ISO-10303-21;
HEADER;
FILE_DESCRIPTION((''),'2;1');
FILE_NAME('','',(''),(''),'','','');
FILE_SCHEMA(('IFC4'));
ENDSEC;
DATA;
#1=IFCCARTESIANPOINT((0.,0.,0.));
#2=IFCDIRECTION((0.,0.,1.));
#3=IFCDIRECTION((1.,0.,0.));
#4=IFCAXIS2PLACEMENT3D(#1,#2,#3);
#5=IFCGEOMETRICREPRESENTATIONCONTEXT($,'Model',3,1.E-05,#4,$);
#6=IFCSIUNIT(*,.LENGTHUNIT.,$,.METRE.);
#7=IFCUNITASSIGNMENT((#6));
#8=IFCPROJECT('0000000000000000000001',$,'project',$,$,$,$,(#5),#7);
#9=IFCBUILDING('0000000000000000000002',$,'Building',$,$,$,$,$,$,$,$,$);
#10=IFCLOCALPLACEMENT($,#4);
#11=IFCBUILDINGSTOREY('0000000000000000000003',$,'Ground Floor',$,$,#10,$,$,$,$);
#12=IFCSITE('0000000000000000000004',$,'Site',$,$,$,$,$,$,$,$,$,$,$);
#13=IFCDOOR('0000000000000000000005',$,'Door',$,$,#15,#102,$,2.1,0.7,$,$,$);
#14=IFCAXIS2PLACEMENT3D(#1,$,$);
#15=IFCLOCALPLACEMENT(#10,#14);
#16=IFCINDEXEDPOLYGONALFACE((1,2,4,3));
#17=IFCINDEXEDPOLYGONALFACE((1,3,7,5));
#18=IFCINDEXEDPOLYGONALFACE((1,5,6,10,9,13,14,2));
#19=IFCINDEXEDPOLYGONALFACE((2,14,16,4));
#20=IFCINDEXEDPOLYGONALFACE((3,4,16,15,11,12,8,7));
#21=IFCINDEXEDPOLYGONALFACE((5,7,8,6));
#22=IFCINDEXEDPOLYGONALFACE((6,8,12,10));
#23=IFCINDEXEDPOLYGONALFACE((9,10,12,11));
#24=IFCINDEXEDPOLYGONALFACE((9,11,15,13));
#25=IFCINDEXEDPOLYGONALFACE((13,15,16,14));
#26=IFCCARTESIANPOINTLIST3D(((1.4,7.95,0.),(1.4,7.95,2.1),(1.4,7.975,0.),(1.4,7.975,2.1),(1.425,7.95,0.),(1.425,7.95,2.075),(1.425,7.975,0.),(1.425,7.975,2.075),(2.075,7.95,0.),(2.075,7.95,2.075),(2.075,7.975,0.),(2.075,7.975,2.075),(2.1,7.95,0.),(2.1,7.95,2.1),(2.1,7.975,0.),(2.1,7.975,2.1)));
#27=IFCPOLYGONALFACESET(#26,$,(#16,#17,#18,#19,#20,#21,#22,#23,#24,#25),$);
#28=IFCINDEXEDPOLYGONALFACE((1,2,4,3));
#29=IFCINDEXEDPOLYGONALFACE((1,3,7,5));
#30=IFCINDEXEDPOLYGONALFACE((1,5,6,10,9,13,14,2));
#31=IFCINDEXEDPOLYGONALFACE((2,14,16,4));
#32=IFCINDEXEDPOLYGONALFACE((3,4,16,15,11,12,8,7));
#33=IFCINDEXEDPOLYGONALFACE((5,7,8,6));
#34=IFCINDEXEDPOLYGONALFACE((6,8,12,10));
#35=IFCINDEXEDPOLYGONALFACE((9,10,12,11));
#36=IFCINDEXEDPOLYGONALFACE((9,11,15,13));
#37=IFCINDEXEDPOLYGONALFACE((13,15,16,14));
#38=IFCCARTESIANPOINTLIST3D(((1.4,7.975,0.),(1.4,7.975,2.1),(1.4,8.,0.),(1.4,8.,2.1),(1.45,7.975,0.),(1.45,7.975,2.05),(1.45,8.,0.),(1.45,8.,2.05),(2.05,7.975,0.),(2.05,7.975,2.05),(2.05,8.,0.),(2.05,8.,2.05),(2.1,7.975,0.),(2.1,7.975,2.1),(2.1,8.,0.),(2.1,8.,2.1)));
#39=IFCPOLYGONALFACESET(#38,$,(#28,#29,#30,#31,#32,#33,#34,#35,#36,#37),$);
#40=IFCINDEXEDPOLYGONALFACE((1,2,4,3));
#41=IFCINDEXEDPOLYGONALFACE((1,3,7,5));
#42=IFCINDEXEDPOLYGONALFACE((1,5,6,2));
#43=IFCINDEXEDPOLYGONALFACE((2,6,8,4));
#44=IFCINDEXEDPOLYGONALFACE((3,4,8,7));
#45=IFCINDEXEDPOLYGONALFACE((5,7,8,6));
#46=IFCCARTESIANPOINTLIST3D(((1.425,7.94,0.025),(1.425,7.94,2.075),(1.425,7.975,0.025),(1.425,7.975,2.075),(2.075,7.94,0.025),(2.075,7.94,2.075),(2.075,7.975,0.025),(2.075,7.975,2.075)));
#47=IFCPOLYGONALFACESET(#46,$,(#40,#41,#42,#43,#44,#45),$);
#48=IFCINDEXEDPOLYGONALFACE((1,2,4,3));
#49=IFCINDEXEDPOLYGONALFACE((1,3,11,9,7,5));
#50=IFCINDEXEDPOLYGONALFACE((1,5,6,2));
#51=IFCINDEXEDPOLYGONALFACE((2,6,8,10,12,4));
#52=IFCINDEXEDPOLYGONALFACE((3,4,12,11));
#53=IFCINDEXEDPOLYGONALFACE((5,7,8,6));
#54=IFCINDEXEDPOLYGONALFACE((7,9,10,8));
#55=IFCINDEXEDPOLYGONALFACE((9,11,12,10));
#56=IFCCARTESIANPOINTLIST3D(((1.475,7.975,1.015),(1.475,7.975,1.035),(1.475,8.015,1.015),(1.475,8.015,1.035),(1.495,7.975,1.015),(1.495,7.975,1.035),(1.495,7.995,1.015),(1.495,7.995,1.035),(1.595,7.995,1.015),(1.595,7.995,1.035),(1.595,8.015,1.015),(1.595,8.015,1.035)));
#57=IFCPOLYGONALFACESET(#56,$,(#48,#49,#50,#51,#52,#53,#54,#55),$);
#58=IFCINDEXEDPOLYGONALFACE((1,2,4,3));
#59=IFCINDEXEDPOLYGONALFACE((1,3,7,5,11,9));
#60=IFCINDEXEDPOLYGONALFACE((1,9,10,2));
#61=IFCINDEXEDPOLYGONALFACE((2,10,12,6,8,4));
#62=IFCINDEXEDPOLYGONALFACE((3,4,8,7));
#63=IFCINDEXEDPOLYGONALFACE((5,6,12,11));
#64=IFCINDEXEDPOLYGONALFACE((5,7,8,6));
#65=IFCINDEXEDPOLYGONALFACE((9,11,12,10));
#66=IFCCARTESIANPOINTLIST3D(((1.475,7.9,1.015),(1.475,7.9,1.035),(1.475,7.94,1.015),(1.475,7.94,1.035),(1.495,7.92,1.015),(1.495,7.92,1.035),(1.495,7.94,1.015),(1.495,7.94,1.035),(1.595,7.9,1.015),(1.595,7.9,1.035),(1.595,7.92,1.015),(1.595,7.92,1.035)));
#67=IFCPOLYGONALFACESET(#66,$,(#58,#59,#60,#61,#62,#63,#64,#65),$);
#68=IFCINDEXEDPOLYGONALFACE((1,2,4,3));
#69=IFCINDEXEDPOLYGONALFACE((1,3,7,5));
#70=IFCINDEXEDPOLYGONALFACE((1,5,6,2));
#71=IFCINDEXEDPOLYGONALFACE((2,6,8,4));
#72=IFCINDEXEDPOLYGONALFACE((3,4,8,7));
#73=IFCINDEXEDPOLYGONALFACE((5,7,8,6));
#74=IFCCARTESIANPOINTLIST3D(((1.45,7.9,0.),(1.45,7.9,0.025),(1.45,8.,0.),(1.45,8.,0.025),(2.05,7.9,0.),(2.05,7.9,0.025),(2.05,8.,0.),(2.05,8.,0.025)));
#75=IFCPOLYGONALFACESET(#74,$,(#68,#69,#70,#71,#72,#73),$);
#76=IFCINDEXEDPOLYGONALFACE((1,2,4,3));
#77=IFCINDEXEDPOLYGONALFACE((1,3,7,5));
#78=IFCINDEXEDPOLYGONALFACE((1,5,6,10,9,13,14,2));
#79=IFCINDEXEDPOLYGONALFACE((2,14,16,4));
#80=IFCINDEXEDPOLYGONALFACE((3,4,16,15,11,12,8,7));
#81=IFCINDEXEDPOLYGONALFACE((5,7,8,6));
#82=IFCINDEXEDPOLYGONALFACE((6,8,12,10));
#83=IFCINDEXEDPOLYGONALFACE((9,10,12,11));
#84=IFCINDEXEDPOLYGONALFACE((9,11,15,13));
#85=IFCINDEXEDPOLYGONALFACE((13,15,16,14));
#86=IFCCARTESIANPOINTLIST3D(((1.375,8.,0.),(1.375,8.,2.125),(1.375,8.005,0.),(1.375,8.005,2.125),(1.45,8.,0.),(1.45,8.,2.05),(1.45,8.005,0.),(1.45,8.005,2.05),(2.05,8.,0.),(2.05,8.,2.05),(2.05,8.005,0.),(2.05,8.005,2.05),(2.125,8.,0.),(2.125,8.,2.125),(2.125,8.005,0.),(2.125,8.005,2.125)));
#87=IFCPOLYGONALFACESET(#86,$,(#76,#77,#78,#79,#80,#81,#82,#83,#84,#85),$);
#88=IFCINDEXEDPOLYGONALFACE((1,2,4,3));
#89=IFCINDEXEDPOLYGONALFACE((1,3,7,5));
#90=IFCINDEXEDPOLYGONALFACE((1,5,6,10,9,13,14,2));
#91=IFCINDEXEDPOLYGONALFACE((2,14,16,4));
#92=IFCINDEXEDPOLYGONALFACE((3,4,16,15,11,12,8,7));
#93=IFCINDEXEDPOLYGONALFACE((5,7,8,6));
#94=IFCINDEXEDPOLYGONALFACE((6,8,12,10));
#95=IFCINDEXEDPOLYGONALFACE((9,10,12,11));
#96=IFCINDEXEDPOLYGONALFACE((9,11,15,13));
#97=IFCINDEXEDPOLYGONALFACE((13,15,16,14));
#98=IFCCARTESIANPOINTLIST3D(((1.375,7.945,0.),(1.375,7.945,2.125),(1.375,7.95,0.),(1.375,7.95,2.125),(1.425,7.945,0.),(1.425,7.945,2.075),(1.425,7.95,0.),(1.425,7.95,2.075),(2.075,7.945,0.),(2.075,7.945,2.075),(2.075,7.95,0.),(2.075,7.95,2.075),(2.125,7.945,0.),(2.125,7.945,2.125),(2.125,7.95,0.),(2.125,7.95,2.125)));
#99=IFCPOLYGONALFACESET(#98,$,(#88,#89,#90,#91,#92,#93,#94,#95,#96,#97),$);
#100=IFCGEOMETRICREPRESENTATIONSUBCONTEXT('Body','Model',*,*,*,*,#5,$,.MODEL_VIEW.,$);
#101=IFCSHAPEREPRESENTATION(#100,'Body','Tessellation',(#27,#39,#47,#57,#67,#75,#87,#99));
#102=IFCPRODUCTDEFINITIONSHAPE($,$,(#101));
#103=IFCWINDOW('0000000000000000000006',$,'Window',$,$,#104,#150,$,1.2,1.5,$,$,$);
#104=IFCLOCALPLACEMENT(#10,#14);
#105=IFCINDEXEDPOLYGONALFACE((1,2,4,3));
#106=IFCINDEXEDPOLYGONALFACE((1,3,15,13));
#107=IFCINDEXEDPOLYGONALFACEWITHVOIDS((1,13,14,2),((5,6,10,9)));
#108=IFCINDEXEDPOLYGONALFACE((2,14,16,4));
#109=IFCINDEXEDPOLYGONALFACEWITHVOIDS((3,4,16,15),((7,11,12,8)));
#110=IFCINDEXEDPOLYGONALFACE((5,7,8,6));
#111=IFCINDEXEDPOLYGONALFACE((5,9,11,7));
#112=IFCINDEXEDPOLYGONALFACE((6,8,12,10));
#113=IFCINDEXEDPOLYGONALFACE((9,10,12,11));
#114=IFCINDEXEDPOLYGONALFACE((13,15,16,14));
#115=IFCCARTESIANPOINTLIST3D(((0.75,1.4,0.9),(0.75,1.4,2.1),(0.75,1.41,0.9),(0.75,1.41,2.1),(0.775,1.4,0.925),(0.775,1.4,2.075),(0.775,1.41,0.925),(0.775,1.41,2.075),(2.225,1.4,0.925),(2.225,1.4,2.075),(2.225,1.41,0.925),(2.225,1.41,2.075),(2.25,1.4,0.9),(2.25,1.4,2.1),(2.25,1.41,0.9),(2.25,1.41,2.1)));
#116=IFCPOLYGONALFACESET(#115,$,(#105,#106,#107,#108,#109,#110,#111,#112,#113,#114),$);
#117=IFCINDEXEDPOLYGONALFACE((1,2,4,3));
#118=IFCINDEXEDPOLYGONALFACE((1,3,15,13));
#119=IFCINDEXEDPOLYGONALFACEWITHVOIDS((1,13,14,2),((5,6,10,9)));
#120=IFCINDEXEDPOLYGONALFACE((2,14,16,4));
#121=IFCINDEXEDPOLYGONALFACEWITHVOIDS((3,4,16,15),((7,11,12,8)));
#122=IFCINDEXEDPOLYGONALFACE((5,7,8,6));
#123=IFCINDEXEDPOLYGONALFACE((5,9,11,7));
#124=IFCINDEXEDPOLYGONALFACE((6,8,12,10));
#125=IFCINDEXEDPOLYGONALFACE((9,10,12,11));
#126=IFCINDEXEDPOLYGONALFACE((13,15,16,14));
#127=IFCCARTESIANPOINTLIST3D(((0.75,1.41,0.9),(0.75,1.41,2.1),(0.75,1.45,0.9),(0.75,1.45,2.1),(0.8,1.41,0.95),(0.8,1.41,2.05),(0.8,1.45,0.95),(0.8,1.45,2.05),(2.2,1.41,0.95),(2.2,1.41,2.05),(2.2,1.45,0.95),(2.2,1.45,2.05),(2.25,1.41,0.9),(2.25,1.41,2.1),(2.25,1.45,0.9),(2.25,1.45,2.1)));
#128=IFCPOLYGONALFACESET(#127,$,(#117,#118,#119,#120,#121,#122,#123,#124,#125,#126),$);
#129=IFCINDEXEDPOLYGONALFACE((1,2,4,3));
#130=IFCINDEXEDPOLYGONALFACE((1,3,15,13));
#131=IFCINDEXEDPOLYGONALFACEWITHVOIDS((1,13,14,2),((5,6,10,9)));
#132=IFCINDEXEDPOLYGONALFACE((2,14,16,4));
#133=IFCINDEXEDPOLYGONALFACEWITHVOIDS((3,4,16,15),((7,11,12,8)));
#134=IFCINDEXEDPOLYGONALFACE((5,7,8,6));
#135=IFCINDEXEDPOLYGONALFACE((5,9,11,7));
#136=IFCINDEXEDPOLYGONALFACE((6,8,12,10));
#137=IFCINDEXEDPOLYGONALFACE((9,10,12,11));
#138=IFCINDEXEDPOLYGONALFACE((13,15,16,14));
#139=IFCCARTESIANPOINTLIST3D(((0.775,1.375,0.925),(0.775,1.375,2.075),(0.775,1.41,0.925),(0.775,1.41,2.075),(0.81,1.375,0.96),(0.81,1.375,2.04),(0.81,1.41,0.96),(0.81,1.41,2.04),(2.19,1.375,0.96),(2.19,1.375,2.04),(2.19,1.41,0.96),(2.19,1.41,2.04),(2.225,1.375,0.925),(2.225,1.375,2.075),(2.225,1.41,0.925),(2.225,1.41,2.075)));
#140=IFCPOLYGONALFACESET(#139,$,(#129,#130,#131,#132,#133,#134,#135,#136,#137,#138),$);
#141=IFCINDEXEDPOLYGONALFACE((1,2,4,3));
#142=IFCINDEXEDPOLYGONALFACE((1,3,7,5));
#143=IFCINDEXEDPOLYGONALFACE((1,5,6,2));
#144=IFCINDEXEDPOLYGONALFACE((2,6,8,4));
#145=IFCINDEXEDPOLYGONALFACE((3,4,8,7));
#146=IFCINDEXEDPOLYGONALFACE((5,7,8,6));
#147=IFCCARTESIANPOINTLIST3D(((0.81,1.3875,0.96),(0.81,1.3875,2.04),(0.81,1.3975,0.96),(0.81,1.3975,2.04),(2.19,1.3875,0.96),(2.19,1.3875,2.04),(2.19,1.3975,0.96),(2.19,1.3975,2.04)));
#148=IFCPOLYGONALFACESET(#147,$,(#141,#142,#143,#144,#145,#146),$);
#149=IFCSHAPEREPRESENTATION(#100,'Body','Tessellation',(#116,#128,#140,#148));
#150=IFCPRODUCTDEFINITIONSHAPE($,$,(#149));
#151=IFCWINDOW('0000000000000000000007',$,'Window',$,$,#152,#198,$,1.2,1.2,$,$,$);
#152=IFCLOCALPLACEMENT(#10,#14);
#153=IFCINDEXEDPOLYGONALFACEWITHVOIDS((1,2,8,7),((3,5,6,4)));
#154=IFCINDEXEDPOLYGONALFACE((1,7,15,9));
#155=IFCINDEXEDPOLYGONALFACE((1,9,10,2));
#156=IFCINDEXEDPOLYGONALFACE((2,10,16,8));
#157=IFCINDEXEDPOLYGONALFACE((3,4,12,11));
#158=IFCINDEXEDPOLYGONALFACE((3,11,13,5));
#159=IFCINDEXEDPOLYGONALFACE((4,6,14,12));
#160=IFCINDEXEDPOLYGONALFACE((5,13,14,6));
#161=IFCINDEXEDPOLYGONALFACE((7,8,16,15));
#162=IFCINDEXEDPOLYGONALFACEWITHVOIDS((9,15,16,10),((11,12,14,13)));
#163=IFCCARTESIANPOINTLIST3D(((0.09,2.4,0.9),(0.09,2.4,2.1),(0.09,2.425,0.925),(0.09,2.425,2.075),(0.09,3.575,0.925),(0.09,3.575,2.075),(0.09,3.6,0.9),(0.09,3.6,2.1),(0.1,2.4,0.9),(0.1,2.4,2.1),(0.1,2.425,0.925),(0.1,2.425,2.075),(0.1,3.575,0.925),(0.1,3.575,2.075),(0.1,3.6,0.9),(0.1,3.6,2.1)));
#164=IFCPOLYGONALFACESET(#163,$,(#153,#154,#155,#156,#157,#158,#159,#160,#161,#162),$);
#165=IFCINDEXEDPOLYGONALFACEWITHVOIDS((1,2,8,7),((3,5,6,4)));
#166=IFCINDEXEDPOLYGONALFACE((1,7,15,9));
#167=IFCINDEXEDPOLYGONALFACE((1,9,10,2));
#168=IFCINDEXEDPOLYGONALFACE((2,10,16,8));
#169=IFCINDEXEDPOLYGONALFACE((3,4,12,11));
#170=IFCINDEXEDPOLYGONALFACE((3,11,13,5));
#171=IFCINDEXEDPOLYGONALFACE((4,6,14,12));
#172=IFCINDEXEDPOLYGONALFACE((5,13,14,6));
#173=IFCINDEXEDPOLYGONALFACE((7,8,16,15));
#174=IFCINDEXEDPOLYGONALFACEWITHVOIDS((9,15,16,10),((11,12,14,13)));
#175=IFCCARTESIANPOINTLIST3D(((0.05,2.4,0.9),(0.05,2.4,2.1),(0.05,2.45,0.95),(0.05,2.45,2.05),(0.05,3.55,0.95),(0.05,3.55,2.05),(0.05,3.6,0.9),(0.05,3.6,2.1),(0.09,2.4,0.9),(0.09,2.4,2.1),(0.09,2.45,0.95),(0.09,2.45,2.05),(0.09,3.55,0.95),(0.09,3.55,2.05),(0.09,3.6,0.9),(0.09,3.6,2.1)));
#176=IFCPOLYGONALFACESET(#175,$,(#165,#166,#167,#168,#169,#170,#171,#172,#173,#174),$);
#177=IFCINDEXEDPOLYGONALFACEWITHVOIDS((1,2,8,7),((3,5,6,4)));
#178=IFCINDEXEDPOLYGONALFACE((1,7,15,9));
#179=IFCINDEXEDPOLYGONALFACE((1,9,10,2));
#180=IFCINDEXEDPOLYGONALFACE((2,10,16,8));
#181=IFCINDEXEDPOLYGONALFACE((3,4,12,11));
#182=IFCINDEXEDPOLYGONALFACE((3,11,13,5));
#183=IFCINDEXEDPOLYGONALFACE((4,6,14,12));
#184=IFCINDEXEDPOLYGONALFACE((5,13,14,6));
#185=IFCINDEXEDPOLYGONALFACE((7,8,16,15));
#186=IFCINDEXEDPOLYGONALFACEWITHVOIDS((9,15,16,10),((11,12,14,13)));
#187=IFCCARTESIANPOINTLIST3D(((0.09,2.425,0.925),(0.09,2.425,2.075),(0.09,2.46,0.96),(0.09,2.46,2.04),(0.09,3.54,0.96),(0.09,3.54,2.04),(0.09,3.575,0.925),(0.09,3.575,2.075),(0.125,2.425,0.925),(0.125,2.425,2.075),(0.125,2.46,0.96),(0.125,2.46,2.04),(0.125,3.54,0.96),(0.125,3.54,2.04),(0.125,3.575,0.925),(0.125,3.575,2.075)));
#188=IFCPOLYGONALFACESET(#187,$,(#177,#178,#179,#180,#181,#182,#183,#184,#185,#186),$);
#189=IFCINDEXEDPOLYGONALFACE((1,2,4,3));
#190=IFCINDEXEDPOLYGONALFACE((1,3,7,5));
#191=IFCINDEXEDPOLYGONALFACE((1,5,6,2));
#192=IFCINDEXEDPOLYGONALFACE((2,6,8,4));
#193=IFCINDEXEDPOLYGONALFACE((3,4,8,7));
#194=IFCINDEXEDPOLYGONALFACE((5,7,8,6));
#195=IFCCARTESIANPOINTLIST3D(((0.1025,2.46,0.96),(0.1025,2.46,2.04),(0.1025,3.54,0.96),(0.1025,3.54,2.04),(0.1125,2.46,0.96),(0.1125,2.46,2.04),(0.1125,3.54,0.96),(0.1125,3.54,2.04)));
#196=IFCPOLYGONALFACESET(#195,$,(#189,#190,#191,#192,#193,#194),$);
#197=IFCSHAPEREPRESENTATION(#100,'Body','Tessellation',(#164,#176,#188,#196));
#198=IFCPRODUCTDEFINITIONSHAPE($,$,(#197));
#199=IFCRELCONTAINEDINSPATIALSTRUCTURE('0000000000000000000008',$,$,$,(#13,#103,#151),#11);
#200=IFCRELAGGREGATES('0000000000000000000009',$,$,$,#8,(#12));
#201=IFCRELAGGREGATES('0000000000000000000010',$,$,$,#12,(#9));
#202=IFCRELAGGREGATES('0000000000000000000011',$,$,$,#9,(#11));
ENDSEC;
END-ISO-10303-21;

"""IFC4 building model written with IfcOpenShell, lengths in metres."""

from ifc_helpers import new_model, si_unit, frame, origin_with_axes, place, context, subcontext, project, spatial, line, indexed_curve, outline, extrude, element, save


model = new_model("IFC4")

# Units and contexts
model_context = context("Model", 3, precision=1e-05, world=origin_with_axes())
body_context = subcontext(model_context, "Body", "Model", "MODEL_VIEW")
ifc_project = project(units=[si_unit("LENGTHUNIT", "METRE")], contexts=[model_context])

# Site, building, storey
site = spatial("IfcSite", under=ifc_project, Name="Site")
building = spatial("IfcBuilding", under=site, Name="Building")
storey_placement = place(None, origin_with_axes())
storey = spatial("IfcBuildingStorey", under=building, at=storey_placement, Name="Ground Floor")

# Door
door_1_placement = place(storey_placement, frame((2.1, 8.0, 0.0), z_axis=(0.0, 0.0, 1.0), x_axis=(-1.0, 0.0, 0.0)))
element("IfcDoor", 1, at=door_1_placement, inside=storey, Name="Door", OverallHeight=2.1, OverallWidth=0.7, context=body_context, shape_type="SweptSolid", body=[
    extrude(outline(indexed_curve([(0.0, 0.0), (0.0, 2.1), (0.7, 2.1), (0.7, 0.0), (0.675, 0.0), (0.675, 2.075), (0.025, 2.075), (0.025, 0.0)], segments=[line(1, 2, 3, 4, 5, 6, 7, 8, 1)])), frame((0.0, 0.025, 0.0), z_axis=(0.0, -1.0, 0.0), x_axis=(1.0, 0.0, 0.0)), (0.0, 0.0, -1.0), 0.025),
    extrude(outline(indexed_curve([(0.0, 0.0), (0.0, 2.1), (0.7, 2.1), (0.7, 0.0), (0.65, 0.0), (0.65, 2.05), (0.05, 2.05), (0.05, 0.0)], segments=[line(1, 2, 3, 4, 5, 6, 7, 8, 1)])), frame((0.0, 0.0, 0.0), z_axis=(0.0, -1.0, 0.0), x_axis=(1.0, 0.0, 0.0)), (0.0, 0.0, -1.0), 0.025),
    extrude(outline(indexed_curve([(0.0, 0.0), (0.65, 0.0), (0.65, 0.035), (0.0, 0.035)], segments=[line(1, 2, 3, 4, 1)])), frame((0.025, 0.025, 0.025), z_axis=(0.0, 0.0, 1.0), x_axis=(1.0, 0.0, 0.0)), (0.0, 0.0, 1.0), 2.05),
    extrude(outline(indexed_curve([(0.0, 0.0), (0.0, -0.04), (-0.12, -0.04), (-0.12, -0.02), (-0.02, -0.02), (-0.02, 0.0)], segments=[line(1, 2, 3, 4, 5, 6, 1)])), frame((0.625, 0.025, 1.015), z_axis=(0.0, 0.0, 1.0), x_axis=(1.0, 0.0, 0.0)), (0.0, 0.0, 1.0), 0.02),
    extrude(outline(indexed_curve([(0.0, 0.0), (0.0, 0.04), (-0.12, 0.04), (-0.12, 0.02), (-0.02, 0.02), (-0.02, 0.0)], segments=[line(1, 2, 3, 4, 5, 6, 1)])), frame((0.625, 0.06, 1.015), z_axis=(0.0, 0.0, 1.0), x_axis=(1.0, 0.0, 0.0)), (0.0, 0.0, 1.0), 0.02),
    extrude(outline(indexed_curve([(0.0, 0.0), (0.6, 0.0), (0.6, 0.1), (0.0, 0.1)], segments=[line(1, 2, 3, 4, 1)])), frame((0.05, 0.0, 0.0), z_axis=(0.0, 0.0, 1.0), x_axis=(1.0, 0.0, 0.0)), (0.0, 0.0, 1.0), 0.025),
    extrude(outline(indexed_curve([(0.0, 0.0), (0.0, 2.125), (0.75, 2.125), (0.75, 0.0), (0.675, 0.0), (0.675, 2.05), (0.075, 2.05), (0.075, 0.0)], segments=[line(1, 2, 3, 4, 5, 6, 7, 8, 1)])), frame((-0.025, -0.005, 0.0), z_axis=(0.0, -1.0, 0.0), x_axis=(1.0, 0.0, 0.0)), (0.0, 0.0, -1.0), 0.005),
    extrude(outline(indexed_curve([(0.0, 0.0), (0.0, 2.125), (0.75, 2.125), (0.75, 0.0), (0.7, 0.0), (0.7, 2.075), (0.05, 2.075), (0.05, 0.0)], segments=[line(1, 2, 3, 4, 5, 6, 7, 8, 1)])), frame((-0.025, 0.05, 0.0), z_axis=(0.0, -1.0, 0.0), x_axis=(1.0, 0.0, 0.0)), (0.0, 0.0, -1.0), 0.005),
])

# Windows
window_1_placement = place(storey_placement, frame((2.25, 1.5, 0.9), z_axis=(0.0, 0.0, 1.0), x_axis=(-1.0, 0.0, 0.0)))
element("IfcWindow", 2, at=window_1_placement, inside=storey, Name="Window", OverallHeight=1.2, OverallWidth=1.5, context=body_context, shape_type="SweptSolid", body=[
    extrude(outline(indexed_curve([(0.0, 0.0), (1.5, 0.0), (1.5, 1.2), (0.0, 1.2)], segments=[line(1, 2, 3, 4, 1)]), holes=[indexed_curve([(0.025, 0.025), (1.475, 0.025), (1.475, 1.175), (0.025, 1.175)], segments=[line(1, 2, 3, 4, 1)])]), frame((0.0, 0.09, 0.0), z_axis=(0.0, -1.0, 0.0), x_axis=(1.0, 0.0, 0.0)), (0.0, 0.0, -1.0), 0.01),
    extrude(outline(indexed_curve([(0.0, 0.0), (1.5, 0.0), (1.5, 1.2), (0.0, 1.2)], segments=[line(1, 2, 3, 4, 1)]), holes=[indexed_curve([(0.05, 0.05), (1.45, 0.05), (1.45, 1.15), (0.05, 1.15)], segments=[line(1, 2, 3, 4, 1)])]), frame((0.0, 0.05, 0.0), z_axis=(0.0, -1.0, 0.0), x_axis=(1.0, 0.0, 0.0)), (0.0, 0.0, -1.0), 0.04),
    extrude(outline(indexed_curve([(0.0, 0.0), (1.45, 0.0), (1.45, 1.15), (0.0, 1.15)], segments=[line(1, 2, 3, 4, 1)]), holes=[indexed_curve([(0.035, 0.035), (1.415, 0.035), (1.415, 1.115), (0.035, 1.115)], segments=[line(1, 2, 3, 4, 1)])]), frame((0.025, 0.09, 0.025), z_axis=(0.0, -1.0, 0.0), x_axis=(1.0, 0.0, 0.0)), (0.0, 0.0, -1.0), 0.035),
    extrude(outline(indexed_curve([(0.035, 0.035), (1.415, 0.035), (1.415, 1.115), (0.035, 1.115)], segments=[line(1, 2, 3, 4, 1)])), frame((0.025, 0.1025, 0.025), z_axis=(0.0, -1.0, 0.0), x_axis=(1.0, 0.0, 0.0)), (0.0, 0.0, -1.0), 0.01),
])
window_2_placement = place(storey_placement, frame((0.0, 3.6, 0.9), z_axis=(0.0, 0.0, 1.0), x_axis=(0.0, -1.0, 0.0)))
element("IfcWindow", 3, at=window_2_placement, inside=storey, Name="Window", OverallHeight=1.2, OverallWidth=1.2, context=body_context, shape_type="SweptSolid", body=[
    extrude(outline(indexed_curve([(0.0, 0.0), (1.2, 0.0), (1.2, 1.2), (0.0, 1.2)], segments=[line(1, 2, 3, 4, 1)]), holes=[indexed_curve([(0.025, 0.025), (1.175, 0.025), (1.175, 1.175), (0.025, 1.175)], segments=[line(1, 2, 3, 4, 1)])]), frame((0.0, 0.09, 0.0), z_axis=(0.0, -1.0, 0.0), x_axis=(1.0, 0.0, 0.0)), (0.0, 0.0, -1.0), 0.01),
    extrude(outline(indexed_curve([(0.0, 0.0), (1.2, 0.0), (1.2, 1.2), (0.0, 1.2)], segments=[line(1, 2, 3, 4, 1)]), holes=[indexed_curve([(0.05, 0.05), (1.15, 0.05), (1.15, 1.15), (0.05, 1.15)], segments=[line(1, 2, 3, 4, 1)])]), frame((0.0, 0.05, 0.0), z_axis=(0.0, -1.0, 0.0), x_axis=(1.0, 0.0, 0.0)), (0.0, 0.0, -1.0), 0.04),
    extrude(outline(indexed_curve([(0.0, 0.0), (1.15, 0.0), (1.15, 1.15), (0.0, 1.15)], segments=[line(1, 2, 3, 4, 1)]), holes=[indexed_curve([(0.035, 0.035), (1.115, 0.035), (1.115, 1.115), (0.035, 1.115)], segments=[line(1, 2, 3, 4, 1)])]), frame((0.025, 0.09, 0.025), z_axis=(0.0, -1.0, 0.0), x_axis=(1.0, 0.0, 0.0)), (0.0, 0.0, -1.0), 0.035),
    extrude(outline(indexed_curve([(0.035, 0.035), (1.115, 0.035), (1.115, 1.115), (0.035, 1.115)], segments=[line(1, 2, 3, 4, 1)])), frame((0.025, 0.1025, 0.025), z_axis=(0.0, -1.0, 0.0), x_axis=(1.0, 0.0, 0.0)), (0.0, 0.0, -1.0), 0.01),
])

save(model, "model.ifc")
